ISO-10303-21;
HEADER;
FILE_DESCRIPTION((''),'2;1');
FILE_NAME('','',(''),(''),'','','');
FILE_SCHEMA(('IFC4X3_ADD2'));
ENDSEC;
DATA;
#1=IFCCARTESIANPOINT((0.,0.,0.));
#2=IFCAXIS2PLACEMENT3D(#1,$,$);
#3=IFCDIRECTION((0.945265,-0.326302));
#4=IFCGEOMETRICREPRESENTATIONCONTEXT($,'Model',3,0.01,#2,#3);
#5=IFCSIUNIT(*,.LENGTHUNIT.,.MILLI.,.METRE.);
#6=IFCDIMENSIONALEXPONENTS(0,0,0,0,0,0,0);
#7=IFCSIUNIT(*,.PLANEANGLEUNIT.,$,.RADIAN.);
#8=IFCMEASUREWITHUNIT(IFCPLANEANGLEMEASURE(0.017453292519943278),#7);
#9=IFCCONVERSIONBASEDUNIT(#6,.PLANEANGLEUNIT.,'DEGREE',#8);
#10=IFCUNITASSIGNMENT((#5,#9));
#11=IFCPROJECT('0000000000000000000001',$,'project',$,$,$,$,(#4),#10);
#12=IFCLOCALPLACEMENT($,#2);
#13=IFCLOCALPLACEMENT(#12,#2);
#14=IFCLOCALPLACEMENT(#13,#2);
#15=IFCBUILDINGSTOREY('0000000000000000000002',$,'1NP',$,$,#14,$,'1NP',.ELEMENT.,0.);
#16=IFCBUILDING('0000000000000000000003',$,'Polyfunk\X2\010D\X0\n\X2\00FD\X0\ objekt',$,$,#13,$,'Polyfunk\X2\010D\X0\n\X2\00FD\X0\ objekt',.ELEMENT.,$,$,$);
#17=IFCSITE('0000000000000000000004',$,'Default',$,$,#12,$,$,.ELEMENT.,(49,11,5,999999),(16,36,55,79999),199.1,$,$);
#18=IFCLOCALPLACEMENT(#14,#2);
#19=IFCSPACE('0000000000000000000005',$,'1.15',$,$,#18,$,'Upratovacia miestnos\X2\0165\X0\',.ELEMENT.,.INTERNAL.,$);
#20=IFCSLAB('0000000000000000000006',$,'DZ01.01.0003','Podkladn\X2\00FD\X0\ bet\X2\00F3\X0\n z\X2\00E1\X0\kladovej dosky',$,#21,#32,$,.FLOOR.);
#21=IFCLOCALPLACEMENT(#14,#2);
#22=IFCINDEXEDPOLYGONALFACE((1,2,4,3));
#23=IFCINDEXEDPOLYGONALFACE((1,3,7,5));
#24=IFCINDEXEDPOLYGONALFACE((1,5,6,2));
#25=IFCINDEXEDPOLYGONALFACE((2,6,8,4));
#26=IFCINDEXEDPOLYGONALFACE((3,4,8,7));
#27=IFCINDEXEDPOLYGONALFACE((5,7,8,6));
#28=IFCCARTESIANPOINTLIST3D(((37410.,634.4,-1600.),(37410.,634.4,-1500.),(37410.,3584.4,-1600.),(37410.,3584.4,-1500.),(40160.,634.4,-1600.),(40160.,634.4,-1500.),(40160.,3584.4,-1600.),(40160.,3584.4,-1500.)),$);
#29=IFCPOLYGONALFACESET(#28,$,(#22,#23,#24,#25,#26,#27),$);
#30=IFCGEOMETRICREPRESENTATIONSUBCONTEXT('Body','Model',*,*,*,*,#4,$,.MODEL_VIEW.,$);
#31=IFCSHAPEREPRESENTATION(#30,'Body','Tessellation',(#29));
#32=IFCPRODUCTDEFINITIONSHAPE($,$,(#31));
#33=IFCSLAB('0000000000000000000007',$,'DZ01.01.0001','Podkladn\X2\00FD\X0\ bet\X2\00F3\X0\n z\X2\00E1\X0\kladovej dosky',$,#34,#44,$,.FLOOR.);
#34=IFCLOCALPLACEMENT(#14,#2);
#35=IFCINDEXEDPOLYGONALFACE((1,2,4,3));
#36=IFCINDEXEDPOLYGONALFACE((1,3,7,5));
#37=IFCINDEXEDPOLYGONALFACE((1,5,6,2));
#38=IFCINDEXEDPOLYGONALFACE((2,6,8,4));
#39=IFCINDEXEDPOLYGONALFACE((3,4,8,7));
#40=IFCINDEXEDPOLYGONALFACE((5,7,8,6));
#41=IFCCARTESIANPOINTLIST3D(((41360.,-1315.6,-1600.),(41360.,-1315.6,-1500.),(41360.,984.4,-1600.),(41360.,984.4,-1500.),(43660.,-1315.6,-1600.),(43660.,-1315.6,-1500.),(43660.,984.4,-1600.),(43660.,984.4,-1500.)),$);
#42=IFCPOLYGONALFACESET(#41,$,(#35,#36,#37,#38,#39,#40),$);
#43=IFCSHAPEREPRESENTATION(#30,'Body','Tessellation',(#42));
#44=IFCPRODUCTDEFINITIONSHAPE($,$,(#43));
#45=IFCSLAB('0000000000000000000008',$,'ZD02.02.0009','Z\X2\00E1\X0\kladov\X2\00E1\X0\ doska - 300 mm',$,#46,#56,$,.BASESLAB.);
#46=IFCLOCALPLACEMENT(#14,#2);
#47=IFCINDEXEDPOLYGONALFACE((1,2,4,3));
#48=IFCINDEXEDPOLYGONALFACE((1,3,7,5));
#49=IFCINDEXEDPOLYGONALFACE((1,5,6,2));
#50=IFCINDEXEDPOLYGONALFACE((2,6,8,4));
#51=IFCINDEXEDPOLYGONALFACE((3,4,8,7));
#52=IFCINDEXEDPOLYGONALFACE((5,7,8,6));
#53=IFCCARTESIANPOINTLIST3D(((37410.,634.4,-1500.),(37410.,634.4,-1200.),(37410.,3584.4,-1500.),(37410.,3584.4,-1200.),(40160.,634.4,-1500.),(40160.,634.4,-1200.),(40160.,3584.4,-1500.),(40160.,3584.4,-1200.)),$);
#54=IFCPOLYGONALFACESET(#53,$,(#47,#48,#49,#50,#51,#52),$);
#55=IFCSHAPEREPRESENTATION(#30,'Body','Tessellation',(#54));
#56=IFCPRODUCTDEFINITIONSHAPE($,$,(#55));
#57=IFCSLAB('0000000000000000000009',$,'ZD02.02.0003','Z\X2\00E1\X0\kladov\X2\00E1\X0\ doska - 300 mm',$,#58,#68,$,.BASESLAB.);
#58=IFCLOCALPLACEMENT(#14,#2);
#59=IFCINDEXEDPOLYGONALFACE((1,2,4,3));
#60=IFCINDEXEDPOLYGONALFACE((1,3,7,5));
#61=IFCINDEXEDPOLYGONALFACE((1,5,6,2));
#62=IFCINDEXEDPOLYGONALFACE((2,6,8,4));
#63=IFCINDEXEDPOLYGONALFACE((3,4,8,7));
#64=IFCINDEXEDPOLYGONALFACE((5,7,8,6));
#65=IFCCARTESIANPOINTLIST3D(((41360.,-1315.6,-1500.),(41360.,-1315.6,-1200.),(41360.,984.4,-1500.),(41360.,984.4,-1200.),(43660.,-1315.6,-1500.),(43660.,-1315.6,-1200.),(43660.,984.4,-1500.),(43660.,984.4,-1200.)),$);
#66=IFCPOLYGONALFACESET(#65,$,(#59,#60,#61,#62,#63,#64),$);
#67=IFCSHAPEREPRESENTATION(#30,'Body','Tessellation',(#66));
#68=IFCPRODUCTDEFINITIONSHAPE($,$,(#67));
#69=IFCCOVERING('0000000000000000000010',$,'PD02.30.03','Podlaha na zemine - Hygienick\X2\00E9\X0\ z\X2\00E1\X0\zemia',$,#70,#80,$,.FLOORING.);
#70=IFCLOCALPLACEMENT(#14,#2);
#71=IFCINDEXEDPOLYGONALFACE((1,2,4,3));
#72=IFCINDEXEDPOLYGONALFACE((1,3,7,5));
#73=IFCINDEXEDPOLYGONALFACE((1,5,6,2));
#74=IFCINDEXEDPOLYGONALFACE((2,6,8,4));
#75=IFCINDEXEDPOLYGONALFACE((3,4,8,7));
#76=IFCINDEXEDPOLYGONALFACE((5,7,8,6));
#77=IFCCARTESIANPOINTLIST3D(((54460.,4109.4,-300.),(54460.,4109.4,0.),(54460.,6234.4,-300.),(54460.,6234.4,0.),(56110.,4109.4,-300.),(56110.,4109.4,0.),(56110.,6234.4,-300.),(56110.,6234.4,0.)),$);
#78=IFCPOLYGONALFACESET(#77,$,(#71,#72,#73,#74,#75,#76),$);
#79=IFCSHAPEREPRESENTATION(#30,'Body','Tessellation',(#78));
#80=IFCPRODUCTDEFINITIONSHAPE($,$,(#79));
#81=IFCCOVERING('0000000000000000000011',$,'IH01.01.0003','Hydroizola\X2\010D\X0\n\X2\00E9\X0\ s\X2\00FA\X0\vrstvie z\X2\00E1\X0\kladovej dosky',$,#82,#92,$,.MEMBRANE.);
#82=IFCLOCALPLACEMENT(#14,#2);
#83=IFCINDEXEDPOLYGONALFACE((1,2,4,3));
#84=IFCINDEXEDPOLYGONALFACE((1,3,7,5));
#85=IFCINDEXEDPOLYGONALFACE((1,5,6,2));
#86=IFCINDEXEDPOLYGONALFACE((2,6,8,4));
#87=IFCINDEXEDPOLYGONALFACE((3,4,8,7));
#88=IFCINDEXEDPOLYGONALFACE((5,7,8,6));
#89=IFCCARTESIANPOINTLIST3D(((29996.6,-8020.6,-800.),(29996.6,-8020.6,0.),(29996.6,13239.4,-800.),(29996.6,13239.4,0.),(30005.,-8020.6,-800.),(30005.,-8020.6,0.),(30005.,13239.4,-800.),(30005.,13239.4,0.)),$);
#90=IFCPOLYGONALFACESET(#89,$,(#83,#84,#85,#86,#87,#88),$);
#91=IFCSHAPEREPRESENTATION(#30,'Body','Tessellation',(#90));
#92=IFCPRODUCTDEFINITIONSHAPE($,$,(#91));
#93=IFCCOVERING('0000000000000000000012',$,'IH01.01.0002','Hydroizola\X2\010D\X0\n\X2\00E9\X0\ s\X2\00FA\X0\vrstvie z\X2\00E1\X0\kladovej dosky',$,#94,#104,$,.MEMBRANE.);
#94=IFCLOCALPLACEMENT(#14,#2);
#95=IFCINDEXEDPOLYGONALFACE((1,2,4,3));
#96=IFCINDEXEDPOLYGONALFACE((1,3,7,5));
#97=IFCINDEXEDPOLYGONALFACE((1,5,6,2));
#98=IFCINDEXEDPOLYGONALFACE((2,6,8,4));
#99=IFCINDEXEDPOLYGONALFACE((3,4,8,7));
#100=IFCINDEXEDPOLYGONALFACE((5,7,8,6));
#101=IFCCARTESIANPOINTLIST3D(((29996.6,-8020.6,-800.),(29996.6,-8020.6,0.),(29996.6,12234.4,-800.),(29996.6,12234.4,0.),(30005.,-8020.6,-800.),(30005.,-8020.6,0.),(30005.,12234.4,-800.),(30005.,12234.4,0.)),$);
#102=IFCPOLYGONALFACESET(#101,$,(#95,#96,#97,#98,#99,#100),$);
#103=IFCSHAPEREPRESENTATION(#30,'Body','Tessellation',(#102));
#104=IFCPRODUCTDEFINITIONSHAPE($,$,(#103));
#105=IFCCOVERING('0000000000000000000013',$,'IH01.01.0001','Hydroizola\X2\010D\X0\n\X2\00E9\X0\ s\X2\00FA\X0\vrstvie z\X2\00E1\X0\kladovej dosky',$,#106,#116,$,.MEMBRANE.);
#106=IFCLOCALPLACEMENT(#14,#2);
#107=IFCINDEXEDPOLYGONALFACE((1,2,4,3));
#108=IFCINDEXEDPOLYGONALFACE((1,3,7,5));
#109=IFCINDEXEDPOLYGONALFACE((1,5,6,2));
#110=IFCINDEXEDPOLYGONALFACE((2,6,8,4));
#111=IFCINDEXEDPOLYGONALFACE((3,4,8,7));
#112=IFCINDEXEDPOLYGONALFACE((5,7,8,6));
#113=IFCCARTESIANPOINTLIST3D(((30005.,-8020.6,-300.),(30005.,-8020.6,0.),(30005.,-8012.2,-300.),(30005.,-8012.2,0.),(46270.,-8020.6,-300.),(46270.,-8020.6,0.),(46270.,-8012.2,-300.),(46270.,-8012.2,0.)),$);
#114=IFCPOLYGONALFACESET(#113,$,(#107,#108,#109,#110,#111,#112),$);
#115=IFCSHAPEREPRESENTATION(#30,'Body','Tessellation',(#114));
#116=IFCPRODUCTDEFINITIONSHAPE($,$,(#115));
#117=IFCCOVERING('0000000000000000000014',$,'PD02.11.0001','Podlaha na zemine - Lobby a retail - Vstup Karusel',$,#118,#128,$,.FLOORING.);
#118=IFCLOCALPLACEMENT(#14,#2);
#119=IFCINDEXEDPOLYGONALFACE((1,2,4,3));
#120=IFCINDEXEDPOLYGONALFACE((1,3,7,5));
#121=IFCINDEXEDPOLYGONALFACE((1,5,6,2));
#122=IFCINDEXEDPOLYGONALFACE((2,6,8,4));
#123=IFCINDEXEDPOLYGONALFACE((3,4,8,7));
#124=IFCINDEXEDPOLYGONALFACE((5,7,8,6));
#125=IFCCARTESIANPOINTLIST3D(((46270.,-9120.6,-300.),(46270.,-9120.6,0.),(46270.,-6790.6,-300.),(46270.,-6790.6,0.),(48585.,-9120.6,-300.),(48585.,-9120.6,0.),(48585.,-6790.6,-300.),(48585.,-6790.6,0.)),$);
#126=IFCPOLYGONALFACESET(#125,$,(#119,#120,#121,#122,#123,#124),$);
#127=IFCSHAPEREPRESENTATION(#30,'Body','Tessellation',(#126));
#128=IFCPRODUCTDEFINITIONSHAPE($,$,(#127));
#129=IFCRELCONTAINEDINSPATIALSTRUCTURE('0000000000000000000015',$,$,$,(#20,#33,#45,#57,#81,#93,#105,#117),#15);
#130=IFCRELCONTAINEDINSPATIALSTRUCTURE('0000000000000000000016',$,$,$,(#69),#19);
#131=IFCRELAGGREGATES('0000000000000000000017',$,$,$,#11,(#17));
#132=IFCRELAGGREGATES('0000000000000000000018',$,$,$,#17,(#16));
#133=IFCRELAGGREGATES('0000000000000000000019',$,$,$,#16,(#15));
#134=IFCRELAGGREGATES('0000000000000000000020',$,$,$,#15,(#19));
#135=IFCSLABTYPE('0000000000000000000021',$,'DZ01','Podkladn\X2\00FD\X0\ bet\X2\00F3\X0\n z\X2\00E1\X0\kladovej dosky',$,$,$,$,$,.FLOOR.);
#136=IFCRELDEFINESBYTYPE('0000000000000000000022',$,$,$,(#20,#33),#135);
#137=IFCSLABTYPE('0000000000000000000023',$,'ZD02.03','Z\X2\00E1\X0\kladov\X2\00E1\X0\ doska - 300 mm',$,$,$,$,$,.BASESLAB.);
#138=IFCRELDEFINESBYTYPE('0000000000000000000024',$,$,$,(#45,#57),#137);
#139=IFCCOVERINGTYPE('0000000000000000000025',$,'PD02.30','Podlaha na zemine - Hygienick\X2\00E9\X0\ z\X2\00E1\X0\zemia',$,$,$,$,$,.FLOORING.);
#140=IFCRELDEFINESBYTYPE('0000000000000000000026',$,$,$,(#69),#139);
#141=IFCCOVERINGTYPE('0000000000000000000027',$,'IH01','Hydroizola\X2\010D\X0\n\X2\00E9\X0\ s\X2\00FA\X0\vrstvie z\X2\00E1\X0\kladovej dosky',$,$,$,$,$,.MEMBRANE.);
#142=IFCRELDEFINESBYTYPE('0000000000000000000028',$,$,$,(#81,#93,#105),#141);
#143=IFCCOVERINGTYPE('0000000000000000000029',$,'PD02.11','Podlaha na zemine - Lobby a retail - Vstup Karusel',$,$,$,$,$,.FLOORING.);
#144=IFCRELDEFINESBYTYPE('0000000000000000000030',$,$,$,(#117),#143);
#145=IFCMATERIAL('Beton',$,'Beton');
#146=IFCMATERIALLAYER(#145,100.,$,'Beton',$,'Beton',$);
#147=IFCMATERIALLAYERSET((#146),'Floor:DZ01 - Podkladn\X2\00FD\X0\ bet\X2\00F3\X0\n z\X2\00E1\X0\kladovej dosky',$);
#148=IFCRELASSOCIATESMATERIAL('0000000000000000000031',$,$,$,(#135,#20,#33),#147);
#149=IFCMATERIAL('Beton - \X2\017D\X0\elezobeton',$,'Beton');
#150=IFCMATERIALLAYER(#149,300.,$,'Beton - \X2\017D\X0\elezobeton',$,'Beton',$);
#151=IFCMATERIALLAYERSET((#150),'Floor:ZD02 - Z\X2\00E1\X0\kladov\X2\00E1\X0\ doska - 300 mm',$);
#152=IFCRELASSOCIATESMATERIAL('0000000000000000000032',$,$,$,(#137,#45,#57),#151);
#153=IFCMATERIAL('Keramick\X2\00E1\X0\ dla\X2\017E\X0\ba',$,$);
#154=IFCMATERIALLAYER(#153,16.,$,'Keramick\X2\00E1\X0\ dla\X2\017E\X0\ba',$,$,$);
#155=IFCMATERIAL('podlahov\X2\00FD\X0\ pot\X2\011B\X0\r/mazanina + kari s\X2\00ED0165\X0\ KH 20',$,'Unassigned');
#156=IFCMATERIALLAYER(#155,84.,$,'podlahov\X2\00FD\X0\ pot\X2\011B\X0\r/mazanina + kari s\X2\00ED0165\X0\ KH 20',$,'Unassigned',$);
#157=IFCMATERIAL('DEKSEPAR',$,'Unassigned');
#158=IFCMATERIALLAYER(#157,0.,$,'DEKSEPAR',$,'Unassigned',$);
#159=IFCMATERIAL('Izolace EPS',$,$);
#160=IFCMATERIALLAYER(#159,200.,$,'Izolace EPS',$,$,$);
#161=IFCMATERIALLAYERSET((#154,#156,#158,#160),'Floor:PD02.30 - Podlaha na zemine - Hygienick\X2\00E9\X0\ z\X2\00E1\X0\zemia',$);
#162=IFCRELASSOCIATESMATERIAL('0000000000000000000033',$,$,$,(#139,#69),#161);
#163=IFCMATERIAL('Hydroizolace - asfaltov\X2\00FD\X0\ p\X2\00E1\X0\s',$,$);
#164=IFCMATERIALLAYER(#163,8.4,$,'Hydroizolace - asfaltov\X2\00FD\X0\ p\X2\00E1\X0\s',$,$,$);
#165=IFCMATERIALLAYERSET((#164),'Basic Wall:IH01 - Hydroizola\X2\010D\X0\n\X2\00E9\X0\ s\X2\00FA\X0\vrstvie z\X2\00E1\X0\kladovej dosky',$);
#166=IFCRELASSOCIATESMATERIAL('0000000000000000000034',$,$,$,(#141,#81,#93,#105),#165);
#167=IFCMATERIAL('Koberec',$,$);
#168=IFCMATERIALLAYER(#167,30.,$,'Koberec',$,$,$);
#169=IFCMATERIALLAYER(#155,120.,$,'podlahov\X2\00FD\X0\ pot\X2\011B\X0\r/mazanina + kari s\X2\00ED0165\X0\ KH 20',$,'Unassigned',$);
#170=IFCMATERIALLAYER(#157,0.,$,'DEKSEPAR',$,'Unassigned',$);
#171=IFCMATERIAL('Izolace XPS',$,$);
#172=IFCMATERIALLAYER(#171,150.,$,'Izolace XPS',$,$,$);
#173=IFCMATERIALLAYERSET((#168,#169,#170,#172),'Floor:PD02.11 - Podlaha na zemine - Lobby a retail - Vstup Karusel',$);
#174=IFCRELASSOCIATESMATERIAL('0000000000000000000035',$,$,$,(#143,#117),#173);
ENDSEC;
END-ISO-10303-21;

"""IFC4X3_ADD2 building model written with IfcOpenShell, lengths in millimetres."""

from ifc_helpers import new_model, entity, si_unit, converted_unit, direction, frame, frame_2d, origin, place, context, subcontext, project, spatial, rectangle, extrude, material, layer, layer_set, layer_usage, type_object, element, save


model = new_model("IFC4X3_ADD2")

# Units and contexts
model_context = context("Model", 3, precision=0.01, world=origin(), true_north=direction((0.945265, -0.326302)))
body_context = subcontext(model_context, "Body", "Model", "MODEL_VIEW")
ifc_project = project(units=[si_unit("LENGTHUNIT", "METRE", prefix="MILLI"), converted_unit("PLANEANGLEUNIT", "DEGREE", entity("IfcPlaneAngleMeasure", 0.017453292519943278), si_unit("PLANEANGLEUNIT", "RADIAN"), dimensions=[0, 0, 0, 0, 0, 0, 0])], contexts=[model_context])

# Site, building, storey
site_placement = place(None, origin())
site = spatial("IfcSite", under=ifc_project, at=site_placement, Name="Default", CompositionType="ELEMENT", RefLatitude=(49, 11, 5, 999999), RefLongitude=(16, 36, 55, 79999), RefElevation=199.1)
building_placement = place(site_placement, origin())
building = spatial("IfcBuilding", under=site, at=building_placement, Name="Polyfunkčný objekt", LongName="Polyfunkčný objekt", CompositionType="ELEMENT")
storey_placement = place(building_placement, origin())
storey = spatial("IfcBuildingStorey", under=building, at=storey_placement, Name="1NP", LongName="1NP", CompositionType="ELEMENT", Elevation=0.0)

# Shared definitions
ifc_material_1 = material(Name="Beton", Category="Beton")
ifc_layer_1 = layer(ifc_material_1, 100.0, Name="Beton", Category="Beton")
ifc_layer_set_1 = layer_set([ifc_layer_1], Name="Floor:DZ01 - Podkladný betón základovej dosky")
slab_type_1 = type_object("IfcSlabType", Name="DZ01", Description="Podkladný betón základovej dosky", PredefinedType="FLOOR", material=ifc_layer_set_1)

# Slabs
ifc_layer_usage_1 = layer_usage(ifc_layer_set_1, "AXIS3", "POSITIVE", 0.0)
slab_1_placement = place(storey_placement, origin())
element("IfcSlab", 1, at=slab_1_placement, inside=storey, type_object=slab_type_1, material=ifc_layer_usage_1, Name="DZ01.01.0003", Description="Podkladný betón základovej dosky", PredefinedType="FLOOR", context=body_context, shape_type="SweptSolid", body=[
    extrude(rectangle(XDim=2950.0, YDim=2750.0, at=frame_2d((0.0, 0.0), x_axis=(1.0, 0.0))), frame((38785.0, 2109.4, -1500.0), z_axis=(0.0, 0.0, -1.0), x_axis=(0.0, 1.0, 0.0)), (0.0, 0.0, 1.0), 100.0),
])
ifc_layer_usage_2 = layer_usage(ifc_layer_set_1, "AXIS3", "POSITIVE", 0.0)
slab_2_placement = place(storey_placement, origin())
element("IfcSlab", 2, at=slab_2_placement, inside=storey, type_object=slab_type_1, material=ifc_layer_usage_2, Name="DZ01.01.0001", Description="Podkladný betón základovej dosky", PredefinedType="FLOOR", context=body_context, shape_type="SweptSolid", body=[
    extrude(rectangle(XDim=2300.0, YDim=2300.0, at=frame_2d((0.0, 0.0), x_axis=(1.0, 0.0))), frame((42510.0, -165.6, -1500.0), z_axis=(0.0, 0.0, -1.0), x_axis=(0.0, 1.0, 0.0)), (0.0, 0.0, 1.0), 100.0),
])
ifc_material_2 = material(Name="Beton - Železobeton", Category="Beton")
ifc_layer_2 = layer(ifc_material_2, 300.0, Name="Beton - Železobeton", Category="Beton")
ifc_layer_set_2 = layer_set([ifc_layer_2], Name="Floor:ZD02 - Základová doska - 300 mm")
ifc_layer_usage_3 = layer_usage(ifc_layer_set_2, "AXIS3", "POSITIVE", 0.0)
slab_type_2 = type_object("IfcSlabType", Name="ZD02.03", Description="Základová doska - 300 mm", PredefinedType="BASESLAB", material=ifc_layer_set_2)
slab_3_placement = place(storey_placement, origin())
element("IfcSlab", 3, at=slab_3_placement, inside=storey, type_object=slab_type_2, material=ifc_layer_usage_3, Name="ZD02.02.0009", Description="Základová doska - 300 mm", PredefinedType="BASESLAB", context=body_context, shape_type="SweptSolid", body=[
    extrude(rectangle(XDim=2950.0, YDim=2750.0, at=frame_2d((0.0, 0.0), x_axis=(1.0, 0.0))), frame((38785.0, 2109.4, -1200.0), z_axis=(0.0, 0.0, -1.0), x_axis=(0.0, 1.0, 0.0)), (0.0, 0.0, 1.0), 300.0),
])
ifc_layer_usage_4 = layer_usage(ifc_layer_set_2, "AXIS3", "POSITIVE", 0.0)
slab_4_placement = place(storey_placement, origin())
element("IfcSlab", 4, at=slab_4_placement, inside=storey, type_object=slab_type_2, material=ifc_layer_usage_4, Name="ZD02.02.0003", Description="Základová doska - 300 mm", PredefinedType="BASESLAB", context=body_context, shape_type="SweptSolid", body=[
    extrude(rectangle(XDim=2300.0, YDim=2300.0, at=frame_2d((0.0, 0.0), x_axis=(1.0, 0.0))), frame((42510.0, -165.6, -1200.0), z_axis=(0.0, 0.0, -1.0), x_axis=(0.0, 1.0, 0.0)), (0.0, 0.0, 1.0), 300.0),
])

# Shared definitions
ifc_material_3 = material(Name="podlahový potěr/mazanina + kari síť KH 20", Category="Unassigned")
ifc_material_4 = material(Name="DEKSEPAR", Category="Unassigned")
ifc_material_5 = material(Name="Izolace EPS")

# Shared definitions
ifc_material_6 = material(Name="Keramická dlažba")
ifc_layer_3 = layer(ifc_material_6, 16.0, Name="Keramická dlažba")
ifc_layer_4 = layer(ifc_material_3, 84.0, Name="podlahový potěr/mazanina + kari síť KH 20", Category="Unassigned")
ifc_layer_5 = layer(ifc_material_4, 0.0, Name="DEKSEPAR", Category="Unassigned")
ifc_layer_6 = layer(ifc_material_5, 200.0, Name="Izolace EPS")
ifc_layer_set_3 = layer_set([ifc_layer_3, ifc_layer_4, ifc_layer_5, ifc_layer_6], Name="Floor:PD02.30 - Podlaha na zemine - Hygienické zázemia")
covering_type_1 = type_object("IfcCoveringType", Name="PD02.30", Description="Podlaha na zemine - Hygienické zázemia", PredefinedType="FLOORING", material=ifc_layer_set_3)

# Shared definitions
space_1_placement = place(storey_placement, origin())
space_1 = spatial("IfcSpace", under=storey, at=space_1_placement, Name="1.15", LongName="Upratovacia miestnosť", CompositionType="ELEMENT", PredefinedType="INTERNAL")

# Covering
ifc_layer_usage_5 = layer_usage(ifc_layer_set_3, "AXIS3", "POSITIVE", 0.0)
covering_1_placement = place(storey_placement, origin())
element("IfcCovering", 5, at=covering_1_placement, inside=space_1, type_object=covering_type_1, material=ifc_layer_usage_5, Name="PD02.30.03", Description="Podlaha na zemine - Hygienické zázemia", PredefinedType="FLOORING", context=body_context, shape_type="SweptSolid", body=[
    extrude(rectangle(XDim=2125.0, YDim=1650.0, at=frame_2d((0.0, 0.0), x_axis=(1.0, 0.0))), frame((55285.0, 5171.9, 0.0), z_axis=(0.0, 0.0, -1.0), x_axis=(0.0, 1.0, 0.0)), (0.0, 0.0, 1.0), 300.0),
])

# Coverings
ifc_material_7 = material(Name="Hydroizolace - asfaltový pás")
ifc_layer_7 = layer(ifc_material_7, 8.4, Name="Hydroizolace - asfaltový pás")
ifc_layer_set_4 = layer_set([ifc_layer_7], Name="Basic Wall:IH01 - Hydroizolačné súvrstvie základovej dosky")
covering_type_2 = type_object("IfcCoveringType", Name="IH01", Description="Hydroizolačné súvrstvie základovej dosky", PredefinedType="MEMBRANE", material=ifc_layer_set_4)
covering_2_placement = place(storey_placement, frame((30000.8, -8020.6, -800.0), z_axis=(0.0, 0.0, 1.0), x_axis=(0.0, 1.0, 0.0)))
element("IfcCovering", 6, at=covering_2_placement, inside=storey, type_object=covering_type_2, material=ifc_layer_set_4, Name="IH01.01.0003", Description="Hydroizolačné súvrstvie základovej dosky", PredefinedType="MEMBRANE", context=body_context, shape_type="SweptSolid", body=[
    extrude(rectangle(XDim=21260.0, YDim=8.4, at=frame_2d((10630.0, 0.0), x_axis=(-1.0, 0.0))), origin(), (0.0, 0.0, 1.0), 800.0),
])
covering_3_placement = place(storey_placement, frame((30000.8, -8020.6, -800.0), z_axis=(0.0, 0.0, 1.0), x_axis=(0.0, 1.0, 0.0)))
element("IfcCovering", 7, at=covering_3_placement, inside=storey, type_object=covering_type_2, material=ifc_layer_set_4, Name="IH01.01.0002", Description="Hydroizolačné súvrstvie základovej dosky", PredefinedType="MEMBRANE", context=body_context, shape_type="SweptSolid", body=[
    extrude(rectangle(XDim=20255.0, YDim=8.4, at=frame_2d((10127.5, 0.0), x_axis=(-1.0, 0.0))), origin(), (0.0, 0.0, 1.0), 800.0),
])
covering_4_placement = place(storey_placement, frame((30005.0, -8016.4, -300.0)))
element("IfcCovering", 8, at=covering_4_placement, inside=storey, type_object=covering_type_2, material=ifc_layer_set_4, Name="IH01.01.0001", Description="Hydroizolačné súvrstvie základovej dosky", PredefinedType="MEMBRANE", context=body_context, shape_type="SweptSolid", body=[
    extrude(rectangle(XDim=16265.0, YDim=8.4, at=frame_2d((8132.5, 0.0), x_axis=(-1.0, 0.0))), origin(), (0.0, 0.0, 1.0), 300.0),
])

# Covering
ifc_material_8 = material(Name="Koberec")
ifc_layer_8 = layer(ifc_material_8, 30.0, Name="Koberec")
ifc_layer_9 = layer(ifc_material_3, 120.0, Name="podlahový potěr/mazanina + kari síť KH 20", Category="Unassigned")
ifc_layer_10 = layer(ifc_material_4, 0.0, Name="DEKSEPAR", Category="Unassigned")
ifc_material_9 = material(Name="Izolace XPS")
ifc_layer_11 = layer(ifc_material_9, 150.0, Name="Izolace XPS")
ifc_layer_set_5 = layer_set([ifc_layer_8, ifc_layer_9, ifc_layer_10, ifc_layer_11], Name="Floor:PD02.11 - Podlaha na zemine - Lobby a retail - Vstup Karusel")
ifc_layer_usage_6 = layer_usage(ifc_layer_set_5, "AXIS3", "POSITIVE", 0.0)
covering_type_3 = type_object("IfcCoveringType", Name="PD02.11", Description="Podlaha na zemine - Lobby a retail - Vstup Karusel", PredefinedType="FLOORING", material=ifc_layer_set_5)
covering_5_placement = place(storey_placement, origin())
element("IfcCovering", 9, at=covering_5_placement, inside=storey, type_object=covering_type_3, material=ifc_layer_usage_6, Name="PD02.11.0001", Description="Podlaha na zemine - Lobby a retail - Vstup Karusel", PredefinedType="FLOORING", context=body_context, shape_type="SweptSolid", body=[
    extrude(rectangle(XDim=2330.0, YDim=2315.0, at=frame_2d((0.0, 0.0), x_axis=(1.0, 0.0))), frame((47427.5, -7955.6, 0.0), z_axis=(0.0, 0.0, -1.0), x_axis=(0.0, 1.0, 0.0)), (0.0, 0.0, 1.0), 300.0),
])

save(model, "model.ifc")
